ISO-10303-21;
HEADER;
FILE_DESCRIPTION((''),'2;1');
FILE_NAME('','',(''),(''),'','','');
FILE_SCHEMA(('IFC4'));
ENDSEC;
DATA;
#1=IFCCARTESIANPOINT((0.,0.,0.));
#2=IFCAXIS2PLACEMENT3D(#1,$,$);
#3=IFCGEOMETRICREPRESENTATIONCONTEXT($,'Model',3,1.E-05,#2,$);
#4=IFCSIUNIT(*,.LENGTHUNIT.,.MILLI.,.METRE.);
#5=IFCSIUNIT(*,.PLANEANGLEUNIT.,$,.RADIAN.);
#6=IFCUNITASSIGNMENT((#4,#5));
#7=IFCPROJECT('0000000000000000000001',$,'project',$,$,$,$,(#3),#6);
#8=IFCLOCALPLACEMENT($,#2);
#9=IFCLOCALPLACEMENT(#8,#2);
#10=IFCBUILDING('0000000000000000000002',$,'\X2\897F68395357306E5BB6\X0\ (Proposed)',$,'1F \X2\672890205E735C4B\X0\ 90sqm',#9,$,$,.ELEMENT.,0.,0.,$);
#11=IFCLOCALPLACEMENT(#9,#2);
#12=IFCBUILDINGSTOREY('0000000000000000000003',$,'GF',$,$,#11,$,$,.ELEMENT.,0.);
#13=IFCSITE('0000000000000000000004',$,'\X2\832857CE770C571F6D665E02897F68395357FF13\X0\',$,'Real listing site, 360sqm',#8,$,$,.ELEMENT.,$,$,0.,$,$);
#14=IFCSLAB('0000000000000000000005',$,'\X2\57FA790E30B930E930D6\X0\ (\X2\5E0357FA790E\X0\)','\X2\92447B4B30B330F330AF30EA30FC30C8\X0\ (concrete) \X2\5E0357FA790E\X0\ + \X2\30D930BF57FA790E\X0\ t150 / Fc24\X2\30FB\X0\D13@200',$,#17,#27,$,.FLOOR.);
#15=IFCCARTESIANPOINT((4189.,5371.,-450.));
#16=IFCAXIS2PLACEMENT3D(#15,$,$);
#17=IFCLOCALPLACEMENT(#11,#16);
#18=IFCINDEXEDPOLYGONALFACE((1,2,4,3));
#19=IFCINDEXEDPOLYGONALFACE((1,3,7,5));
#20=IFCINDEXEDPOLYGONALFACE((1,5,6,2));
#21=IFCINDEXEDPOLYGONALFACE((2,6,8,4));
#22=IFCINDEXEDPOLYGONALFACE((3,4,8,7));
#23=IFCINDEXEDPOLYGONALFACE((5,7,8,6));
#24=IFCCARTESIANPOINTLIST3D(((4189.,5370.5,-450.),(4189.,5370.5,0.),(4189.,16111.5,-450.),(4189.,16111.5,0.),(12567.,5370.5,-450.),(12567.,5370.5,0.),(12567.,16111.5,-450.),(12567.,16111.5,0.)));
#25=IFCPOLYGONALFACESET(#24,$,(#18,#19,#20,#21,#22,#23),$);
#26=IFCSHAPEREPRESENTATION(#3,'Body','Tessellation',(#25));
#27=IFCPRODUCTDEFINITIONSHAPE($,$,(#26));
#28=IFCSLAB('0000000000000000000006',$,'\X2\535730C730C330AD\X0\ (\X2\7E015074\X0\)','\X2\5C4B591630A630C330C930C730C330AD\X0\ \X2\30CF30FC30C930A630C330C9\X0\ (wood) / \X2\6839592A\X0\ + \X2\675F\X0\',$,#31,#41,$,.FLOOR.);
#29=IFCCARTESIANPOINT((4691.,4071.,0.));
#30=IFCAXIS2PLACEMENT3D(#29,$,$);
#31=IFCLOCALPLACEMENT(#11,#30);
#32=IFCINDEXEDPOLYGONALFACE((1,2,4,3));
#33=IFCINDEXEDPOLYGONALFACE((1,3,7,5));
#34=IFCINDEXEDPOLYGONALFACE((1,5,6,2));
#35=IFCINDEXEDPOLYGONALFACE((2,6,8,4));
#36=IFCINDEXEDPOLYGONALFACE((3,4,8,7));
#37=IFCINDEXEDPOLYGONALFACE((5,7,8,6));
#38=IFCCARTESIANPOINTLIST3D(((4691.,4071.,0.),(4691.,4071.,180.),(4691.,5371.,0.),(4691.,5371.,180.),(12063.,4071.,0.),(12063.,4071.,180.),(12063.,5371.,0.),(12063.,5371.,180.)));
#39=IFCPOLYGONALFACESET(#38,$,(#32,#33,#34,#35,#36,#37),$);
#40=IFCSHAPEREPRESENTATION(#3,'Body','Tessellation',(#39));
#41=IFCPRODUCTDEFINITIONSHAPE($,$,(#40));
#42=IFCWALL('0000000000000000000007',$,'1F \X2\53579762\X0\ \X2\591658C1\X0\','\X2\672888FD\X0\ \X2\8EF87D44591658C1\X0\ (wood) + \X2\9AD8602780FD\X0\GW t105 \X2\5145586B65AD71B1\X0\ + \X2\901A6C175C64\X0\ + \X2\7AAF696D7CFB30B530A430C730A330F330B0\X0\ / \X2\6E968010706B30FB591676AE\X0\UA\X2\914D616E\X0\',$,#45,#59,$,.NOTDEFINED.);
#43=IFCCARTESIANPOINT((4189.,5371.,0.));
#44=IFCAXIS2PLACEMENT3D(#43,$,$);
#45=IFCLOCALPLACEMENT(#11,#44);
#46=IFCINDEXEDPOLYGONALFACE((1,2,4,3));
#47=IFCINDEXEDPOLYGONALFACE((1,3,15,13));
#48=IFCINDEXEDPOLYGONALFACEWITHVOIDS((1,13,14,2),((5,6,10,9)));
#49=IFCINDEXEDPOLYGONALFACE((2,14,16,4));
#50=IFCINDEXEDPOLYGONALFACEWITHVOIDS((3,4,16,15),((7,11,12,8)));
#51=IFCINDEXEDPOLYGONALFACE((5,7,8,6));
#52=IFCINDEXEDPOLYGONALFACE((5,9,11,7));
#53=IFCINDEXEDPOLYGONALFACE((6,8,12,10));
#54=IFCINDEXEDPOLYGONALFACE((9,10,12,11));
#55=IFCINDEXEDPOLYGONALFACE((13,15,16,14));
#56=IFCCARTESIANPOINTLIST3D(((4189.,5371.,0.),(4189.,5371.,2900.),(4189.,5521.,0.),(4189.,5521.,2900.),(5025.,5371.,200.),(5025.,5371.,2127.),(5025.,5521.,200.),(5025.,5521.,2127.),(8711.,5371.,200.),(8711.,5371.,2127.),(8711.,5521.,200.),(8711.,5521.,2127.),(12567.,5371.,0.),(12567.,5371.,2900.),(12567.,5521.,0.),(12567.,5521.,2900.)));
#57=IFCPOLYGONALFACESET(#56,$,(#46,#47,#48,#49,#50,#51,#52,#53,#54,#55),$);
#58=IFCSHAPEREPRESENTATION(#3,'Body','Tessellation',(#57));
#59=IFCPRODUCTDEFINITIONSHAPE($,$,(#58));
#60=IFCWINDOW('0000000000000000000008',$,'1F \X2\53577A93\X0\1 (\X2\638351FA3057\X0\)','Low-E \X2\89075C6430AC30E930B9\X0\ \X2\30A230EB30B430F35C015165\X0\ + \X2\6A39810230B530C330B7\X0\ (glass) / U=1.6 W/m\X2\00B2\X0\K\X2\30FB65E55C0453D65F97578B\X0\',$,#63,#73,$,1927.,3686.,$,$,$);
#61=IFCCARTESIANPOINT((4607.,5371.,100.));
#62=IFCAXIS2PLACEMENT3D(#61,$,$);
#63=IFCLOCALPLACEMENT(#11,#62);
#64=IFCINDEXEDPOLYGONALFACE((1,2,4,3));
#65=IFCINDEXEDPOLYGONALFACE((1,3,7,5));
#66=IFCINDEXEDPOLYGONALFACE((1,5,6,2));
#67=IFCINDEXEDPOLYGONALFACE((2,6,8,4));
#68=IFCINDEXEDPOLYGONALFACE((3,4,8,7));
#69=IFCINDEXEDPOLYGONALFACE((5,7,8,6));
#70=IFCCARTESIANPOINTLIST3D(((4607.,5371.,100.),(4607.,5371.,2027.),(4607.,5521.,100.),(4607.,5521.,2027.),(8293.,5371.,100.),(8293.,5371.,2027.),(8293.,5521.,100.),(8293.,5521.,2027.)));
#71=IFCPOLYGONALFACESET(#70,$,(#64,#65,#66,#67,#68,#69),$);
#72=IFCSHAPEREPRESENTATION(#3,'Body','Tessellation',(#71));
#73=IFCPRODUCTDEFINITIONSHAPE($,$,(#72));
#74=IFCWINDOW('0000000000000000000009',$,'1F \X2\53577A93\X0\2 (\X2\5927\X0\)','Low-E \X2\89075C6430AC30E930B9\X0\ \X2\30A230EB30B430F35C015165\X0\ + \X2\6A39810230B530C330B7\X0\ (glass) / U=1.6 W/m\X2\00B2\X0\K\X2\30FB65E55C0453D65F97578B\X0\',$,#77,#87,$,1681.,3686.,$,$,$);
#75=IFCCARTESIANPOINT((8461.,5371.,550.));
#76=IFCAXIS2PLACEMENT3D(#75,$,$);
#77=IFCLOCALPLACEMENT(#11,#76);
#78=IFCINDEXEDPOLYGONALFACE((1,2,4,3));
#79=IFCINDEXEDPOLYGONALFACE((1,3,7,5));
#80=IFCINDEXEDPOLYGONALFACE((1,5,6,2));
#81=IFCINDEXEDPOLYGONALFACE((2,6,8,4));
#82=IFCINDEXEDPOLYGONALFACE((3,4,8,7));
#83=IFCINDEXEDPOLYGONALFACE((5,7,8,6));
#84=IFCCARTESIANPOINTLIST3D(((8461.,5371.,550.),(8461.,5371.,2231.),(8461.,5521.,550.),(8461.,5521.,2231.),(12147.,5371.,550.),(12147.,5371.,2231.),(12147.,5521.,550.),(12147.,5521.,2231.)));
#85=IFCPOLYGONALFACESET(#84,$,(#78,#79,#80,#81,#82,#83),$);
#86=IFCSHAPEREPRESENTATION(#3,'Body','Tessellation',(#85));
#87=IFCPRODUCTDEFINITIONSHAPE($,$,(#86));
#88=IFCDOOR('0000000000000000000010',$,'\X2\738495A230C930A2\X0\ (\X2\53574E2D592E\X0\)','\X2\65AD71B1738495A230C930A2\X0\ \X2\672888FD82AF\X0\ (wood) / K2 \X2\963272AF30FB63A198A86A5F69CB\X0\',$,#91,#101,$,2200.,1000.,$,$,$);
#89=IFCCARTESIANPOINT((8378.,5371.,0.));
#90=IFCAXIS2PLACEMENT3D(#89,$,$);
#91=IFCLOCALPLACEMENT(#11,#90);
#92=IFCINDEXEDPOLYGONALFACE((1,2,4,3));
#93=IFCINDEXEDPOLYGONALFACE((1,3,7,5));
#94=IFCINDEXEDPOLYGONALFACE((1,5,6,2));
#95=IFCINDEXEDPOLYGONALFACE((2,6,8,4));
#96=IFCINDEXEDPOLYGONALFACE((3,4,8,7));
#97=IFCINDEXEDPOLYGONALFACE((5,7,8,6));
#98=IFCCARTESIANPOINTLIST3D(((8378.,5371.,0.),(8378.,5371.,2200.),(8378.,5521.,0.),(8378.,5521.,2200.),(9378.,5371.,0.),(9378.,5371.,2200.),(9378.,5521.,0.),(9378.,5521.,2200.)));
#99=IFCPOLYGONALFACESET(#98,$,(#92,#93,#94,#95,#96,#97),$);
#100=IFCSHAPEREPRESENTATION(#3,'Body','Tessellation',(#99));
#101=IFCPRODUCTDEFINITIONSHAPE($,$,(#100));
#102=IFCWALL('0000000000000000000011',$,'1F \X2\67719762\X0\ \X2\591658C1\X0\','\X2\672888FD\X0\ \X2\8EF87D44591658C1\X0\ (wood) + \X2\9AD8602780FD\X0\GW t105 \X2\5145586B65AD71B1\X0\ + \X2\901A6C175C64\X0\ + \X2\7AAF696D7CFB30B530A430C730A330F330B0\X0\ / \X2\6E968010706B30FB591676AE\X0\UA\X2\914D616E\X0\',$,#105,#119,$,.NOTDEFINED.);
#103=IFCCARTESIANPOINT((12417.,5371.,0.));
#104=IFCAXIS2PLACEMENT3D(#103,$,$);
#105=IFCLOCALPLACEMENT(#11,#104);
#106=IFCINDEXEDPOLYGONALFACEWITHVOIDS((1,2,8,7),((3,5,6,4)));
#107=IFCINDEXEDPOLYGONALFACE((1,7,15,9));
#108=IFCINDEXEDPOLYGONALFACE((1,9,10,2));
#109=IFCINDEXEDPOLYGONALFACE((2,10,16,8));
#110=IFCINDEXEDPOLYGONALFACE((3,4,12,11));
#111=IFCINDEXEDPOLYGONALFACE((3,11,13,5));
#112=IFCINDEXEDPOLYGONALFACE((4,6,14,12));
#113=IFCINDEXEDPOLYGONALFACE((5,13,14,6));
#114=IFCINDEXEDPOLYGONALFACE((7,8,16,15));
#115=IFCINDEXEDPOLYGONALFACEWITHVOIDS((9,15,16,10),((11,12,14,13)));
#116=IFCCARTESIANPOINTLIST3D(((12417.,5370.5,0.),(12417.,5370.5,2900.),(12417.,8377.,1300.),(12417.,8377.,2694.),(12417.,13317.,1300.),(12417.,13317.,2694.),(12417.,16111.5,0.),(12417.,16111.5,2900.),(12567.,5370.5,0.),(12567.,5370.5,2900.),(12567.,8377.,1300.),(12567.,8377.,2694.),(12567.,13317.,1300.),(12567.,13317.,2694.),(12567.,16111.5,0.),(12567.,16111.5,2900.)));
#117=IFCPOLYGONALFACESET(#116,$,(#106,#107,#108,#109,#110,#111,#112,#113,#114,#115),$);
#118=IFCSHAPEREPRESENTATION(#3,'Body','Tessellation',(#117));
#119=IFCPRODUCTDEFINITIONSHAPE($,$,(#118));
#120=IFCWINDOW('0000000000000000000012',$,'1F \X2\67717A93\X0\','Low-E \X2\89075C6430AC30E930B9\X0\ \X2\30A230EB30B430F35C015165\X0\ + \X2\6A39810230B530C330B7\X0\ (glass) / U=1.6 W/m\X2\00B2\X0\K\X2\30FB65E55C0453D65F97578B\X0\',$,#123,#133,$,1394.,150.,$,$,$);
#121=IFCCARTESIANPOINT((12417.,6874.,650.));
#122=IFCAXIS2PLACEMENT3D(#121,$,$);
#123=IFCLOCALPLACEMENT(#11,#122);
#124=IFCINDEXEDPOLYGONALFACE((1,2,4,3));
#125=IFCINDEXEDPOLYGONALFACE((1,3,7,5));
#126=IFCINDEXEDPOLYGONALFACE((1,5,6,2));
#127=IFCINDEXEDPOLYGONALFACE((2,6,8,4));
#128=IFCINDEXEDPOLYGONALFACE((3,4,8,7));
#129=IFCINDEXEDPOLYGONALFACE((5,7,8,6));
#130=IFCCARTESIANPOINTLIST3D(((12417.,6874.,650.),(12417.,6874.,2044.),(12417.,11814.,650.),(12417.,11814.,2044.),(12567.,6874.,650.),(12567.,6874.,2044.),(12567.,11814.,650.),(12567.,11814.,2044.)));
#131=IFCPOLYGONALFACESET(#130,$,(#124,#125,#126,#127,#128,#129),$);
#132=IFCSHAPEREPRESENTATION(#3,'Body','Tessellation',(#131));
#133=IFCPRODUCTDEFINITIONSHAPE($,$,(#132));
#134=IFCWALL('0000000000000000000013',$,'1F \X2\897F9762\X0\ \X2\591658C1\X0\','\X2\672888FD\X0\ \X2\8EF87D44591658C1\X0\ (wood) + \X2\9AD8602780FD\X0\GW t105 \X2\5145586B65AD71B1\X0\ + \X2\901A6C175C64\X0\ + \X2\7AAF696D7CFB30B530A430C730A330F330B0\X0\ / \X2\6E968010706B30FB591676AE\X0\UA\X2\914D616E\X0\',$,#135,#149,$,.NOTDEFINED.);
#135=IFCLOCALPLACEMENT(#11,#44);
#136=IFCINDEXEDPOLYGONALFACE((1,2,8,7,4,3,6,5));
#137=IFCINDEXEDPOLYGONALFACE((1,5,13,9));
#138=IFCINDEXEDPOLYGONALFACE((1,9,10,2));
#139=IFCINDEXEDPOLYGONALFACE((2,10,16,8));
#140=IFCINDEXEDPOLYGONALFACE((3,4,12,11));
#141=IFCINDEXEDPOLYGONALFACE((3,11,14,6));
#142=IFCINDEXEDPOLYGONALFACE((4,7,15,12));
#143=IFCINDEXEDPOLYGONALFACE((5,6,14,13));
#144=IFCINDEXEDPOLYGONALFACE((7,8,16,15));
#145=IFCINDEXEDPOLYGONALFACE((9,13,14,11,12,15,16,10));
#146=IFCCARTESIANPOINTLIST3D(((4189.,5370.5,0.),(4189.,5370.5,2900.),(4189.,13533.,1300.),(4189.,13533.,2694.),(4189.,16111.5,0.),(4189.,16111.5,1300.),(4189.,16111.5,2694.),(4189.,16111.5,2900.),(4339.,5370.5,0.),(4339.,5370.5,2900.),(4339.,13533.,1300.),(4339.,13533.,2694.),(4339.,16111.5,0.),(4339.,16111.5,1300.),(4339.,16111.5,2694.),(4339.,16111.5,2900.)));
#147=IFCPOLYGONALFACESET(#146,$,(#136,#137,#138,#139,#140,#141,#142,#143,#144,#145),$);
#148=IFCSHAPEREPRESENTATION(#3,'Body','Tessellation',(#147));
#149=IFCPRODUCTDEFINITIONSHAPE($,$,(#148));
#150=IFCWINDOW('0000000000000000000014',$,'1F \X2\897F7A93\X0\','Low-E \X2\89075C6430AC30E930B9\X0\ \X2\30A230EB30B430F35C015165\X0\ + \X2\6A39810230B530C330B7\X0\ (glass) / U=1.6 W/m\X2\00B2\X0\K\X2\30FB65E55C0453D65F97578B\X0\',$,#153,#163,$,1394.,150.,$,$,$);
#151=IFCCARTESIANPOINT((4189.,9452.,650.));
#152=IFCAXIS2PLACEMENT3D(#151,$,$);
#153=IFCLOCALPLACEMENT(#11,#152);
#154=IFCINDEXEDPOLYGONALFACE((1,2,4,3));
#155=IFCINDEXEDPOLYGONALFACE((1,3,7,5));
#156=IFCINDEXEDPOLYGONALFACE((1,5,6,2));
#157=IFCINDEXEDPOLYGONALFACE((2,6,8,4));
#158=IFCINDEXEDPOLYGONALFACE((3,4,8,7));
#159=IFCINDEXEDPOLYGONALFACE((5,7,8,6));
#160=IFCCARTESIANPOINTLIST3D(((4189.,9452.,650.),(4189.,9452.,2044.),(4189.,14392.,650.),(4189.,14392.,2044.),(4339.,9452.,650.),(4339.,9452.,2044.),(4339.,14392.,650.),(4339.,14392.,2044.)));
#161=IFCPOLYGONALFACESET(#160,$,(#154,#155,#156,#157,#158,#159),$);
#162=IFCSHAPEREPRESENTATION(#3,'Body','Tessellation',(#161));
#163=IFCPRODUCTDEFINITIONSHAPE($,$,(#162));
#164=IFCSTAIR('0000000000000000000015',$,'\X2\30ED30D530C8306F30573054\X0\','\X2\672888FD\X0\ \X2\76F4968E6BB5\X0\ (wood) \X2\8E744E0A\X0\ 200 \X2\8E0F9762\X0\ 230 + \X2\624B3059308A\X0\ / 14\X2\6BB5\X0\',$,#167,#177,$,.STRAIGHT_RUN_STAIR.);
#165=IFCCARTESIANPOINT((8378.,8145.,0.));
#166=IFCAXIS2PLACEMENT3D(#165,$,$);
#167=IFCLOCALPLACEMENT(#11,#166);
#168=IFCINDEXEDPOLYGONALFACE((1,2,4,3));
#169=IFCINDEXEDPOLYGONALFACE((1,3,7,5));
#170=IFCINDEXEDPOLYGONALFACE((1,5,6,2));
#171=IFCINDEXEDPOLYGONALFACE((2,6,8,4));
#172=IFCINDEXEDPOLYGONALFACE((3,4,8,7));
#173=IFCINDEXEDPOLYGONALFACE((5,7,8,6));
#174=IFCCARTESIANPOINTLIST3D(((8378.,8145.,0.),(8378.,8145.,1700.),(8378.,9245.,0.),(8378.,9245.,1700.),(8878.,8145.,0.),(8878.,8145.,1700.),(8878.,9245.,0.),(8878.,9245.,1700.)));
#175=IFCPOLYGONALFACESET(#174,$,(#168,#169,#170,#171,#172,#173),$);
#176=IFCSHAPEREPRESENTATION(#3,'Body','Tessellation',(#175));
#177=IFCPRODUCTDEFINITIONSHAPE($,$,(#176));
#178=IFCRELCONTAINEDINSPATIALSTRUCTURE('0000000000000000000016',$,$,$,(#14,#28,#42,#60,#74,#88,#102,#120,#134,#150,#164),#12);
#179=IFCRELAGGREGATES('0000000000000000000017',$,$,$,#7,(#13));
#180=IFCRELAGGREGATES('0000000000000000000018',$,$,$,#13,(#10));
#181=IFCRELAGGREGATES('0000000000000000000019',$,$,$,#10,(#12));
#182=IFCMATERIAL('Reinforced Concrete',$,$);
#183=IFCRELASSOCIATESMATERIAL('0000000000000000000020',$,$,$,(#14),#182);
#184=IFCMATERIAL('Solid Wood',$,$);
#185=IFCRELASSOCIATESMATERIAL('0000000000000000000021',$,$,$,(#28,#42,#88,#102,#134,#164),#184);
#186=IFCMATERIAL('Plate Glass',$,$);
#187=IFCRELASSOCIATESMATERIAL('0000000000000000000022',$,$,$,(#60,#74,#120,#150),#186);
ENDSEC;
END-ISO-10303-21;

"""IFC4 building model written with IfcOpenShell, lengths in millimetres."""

from ifc_helpers import new_model, si_unit, frame, frame_2d, origin, place, context, project, spatial, rectangle, extrude, material, element, fill, save


model = new_model("IFC4")

# Units and contexts
model_context = context("Model", 3, precision=1e-05, world=origin())
ifc_project = project(units=[si_unit("LENGTHUNIT", "METRE", prefix="MILLI"), si_unit("PLANEANGLEUNIT", "RADIAN")], contexts=[model_context])

# Site, building, storey
site_placement = place(None, origin())
site = spatial("IfcSite", under=ifc_project, at=site_placement, Name="茨城県土浦市西根南３", ObjectType="Real listing site, 360sqm", CompositionType="ELEMENT", RefElevation=0.0)
building_placement = place(site_placement, origin())
building = spatial("IfcBuilding", under=site, at=building_placement, Name="西根南の家 (Proposed)", ObjectType="1F 木造平屋 90sqm", CompositionType="ELEMENT", ElevationOfRefHeight=0.0, ElevationOfTerrain=0.0)
storey_placement = place(building_placement, origin())
storey = spatial("IfcBuildingStorey", under=building, at=storey_placement, Name="GF", CompositionType="ELEMENT", Elevation=0.0)

# Slabs
ifc_material_1 = material(Name="Reinforced Concrete")
slab_1_placement = place(storey_placement, frame((4189.0, 5371.0, -450.0)))
element("IfcSlab", 1, at=slab_1_placement, inside=storey, material=ifc_material_1, Name="基礎スラブ (布基礎)", Description="鉄筋コンクリート (concrete) 布基礎 + ベタ基礎 t150 / Fc24・D13@200", PredefinedType="FLOOR", context=model_context, shape_type="SweptSolid", body=[
    extrude(rectangle(XDim=8378.0, YDim=10741.0, at=frame_2d((4189.0, 5370.0))), frame((4189.0, 5371.0, -450.0)), (0.0, 0.0, 1.0), 450.0),
])
ifc_material_2 = material(Name="Solid Wood")
slab_2_placement = place(storey_placement, frame((4691.0, 4071.0, 0.0)))
element("IfcSlab", 2, at=slab_2_placement, inside=storey, material=ifc_material_2, Name="南デッキ (縁側)", Description="屋外ウッドデッキ ハードウッド (wood) / 根太 + 束", PredefinedType="FLOOR", context=model_context, shape_type="SweptSolid", body=[
    extrude(rectangle(XDim=7372.0, YDim=1300.0, at=frame_2d((3686.0, 650.0))), frame((4691.0, 4071.0, 0.0)), (0.0, 0.0, 1.0), 180.0),
])

# Wall, openings, windows, door
wall_1_placement = place(storey_placement, frame((4189.0, 5371.0, 0.0)))
wall_1 = element("IfcWall", 3, at=wall_1_placement, inside=storey, material=ifc_material_2, Name="1F 南面 外壁", Description="木製 軸組外壁 (wood) + 高性能GW t105 充填断熱 + 通気層 + 窯業系サイディング / 準耐火・外皮UA配慮", PredefinedType="NOTDEFINED", context=model_context, shape_type="SweptSolid", body=[
    extrude(rectangle(XDim=8378.0, YDim=150.0, at=frame_2d((4189.0, 75.0))), frame((4189.0, 5371.0, 0.0)), (0.0, 0.0, 1.0), 2900.0),
])
opening_1_placement = place(storey_placement, frame((4607.0, 5371.0, 100.0)))
opening_1 = element("IfcOpeningElement", 4, at=opening_1_placement, cuts=wall_1, PredefinedType="NOTDEFINED", context=model_context, shape_type="SweptSolid", body=[
    extrude(rectangle(XDim=3686.0, YDim=150.0, at=frame_2d((1843.0, 75.0))), frame((4607.0, 5371.0, 100.0)), (0.0, 0.0, 1.0), 1927.0),
])
opening_2_placement = place(storey_placement, frame((8461.0, 5371.0, 550.0)))
opening_2 = element("IfcOpeningElement", 5, at=opening_2_placement, cuts=wall_1, PredefinedType="NOTDEFINED", context=model_context, shape_type="SweptSolid", body=[
    extrude(rectangle(XDim=3686.0, YDim=150.0, at=frame_2d((1843.0, 75.0))), frame((8461.0, 5371.0, 550.0)), (0.0, 0.0, 1.0), 1681.0),
])
opening_3_placement = place(storey_placement, frame((8378.0, 5371.0, 0.0)))
opening_3 = element("IfcOpeningElement", 6, at=opening_3_placement, cuts=wall_1, PredefinedType="NOTDEFINED", context=model_context, shape_type="SweptSolid", body=[
    extrude(rectangle(XDim=1000.0, YDim=150.0, at=frame_2d((500.0, 75.0))), frame((8378.0, 5371.0, 0.0)), (0.0, 0.0, 1.0), 2200.0),
])
ifc_material_3 = material(Name="Plate Glass")
window_1_placement = place(storey_placement, frame((4607.0, 5371.0, 100.0)))
window_1 = element("IfcWindow", 7, at=window_1_placement, inside=storey, material=ifc_material_3, Name="1F 南窓1 (掃出し)", Description="Low-E 複層ガラス アルゴン封入 + 樹脂サッシ (glass) / U=1.6 W/m²K・日射取得型", OverallHeight=1927.0, OverallWidth=3686.0, context=model_context, shape_type="SweptSolid", body=[
    extrude(rectangle(XDim=3686.0, YDim=150.0, at=frame_2d((1843.0, 75.0))), frame((4607.0, 5371.0, 100.0)), (0.0, 0.0, 1.0), 1927.0),
])
fill(opening_1, window_1)
window_2_placement = place(storey_placement, frame((8461.0, 5371.0, 550.0)))
window_2 = element("IfcWindow", 8, at=window_2_placement, inside=storey, material=ifc_material_3, Name="1F 南窓2 (大)", Description="Low-E 複層ガラス アルゴン封入 + 樹脂サッシ (glass) / U=1.6 W/m²K・日射取得型", OverallHeight=1681.0, OverallWidth=3686.0, context=model_context, shape_type="SweptSolid", body=[
    extrude(rectangle(XDim=3686.0, YDim=150.0, at=frame_2d((1843.0, 75.0))), frame((8461.0, 5371.0, 550.0)), (0.0, 0.0, 1.0), 1681.0),
])
fill(opening_2, window_2)
door_placement = place(storey_placement, frame((8378.0, 5371.0, 0.0)))
door = element("IfcDoor", 9, at=door_placement, inside=storey, material=ifc_material_2, Name="玄関ドア (南中央)", Description="断熱玄関ドア 木製芯 (wood) / K2 防犯・採風機構", OverallHeight=2200.0, OverallWidth=1000.0, context=model_context, shape_type="SweptSolid", body=[
    extrude(rectangle(XDim=1000.0, YDim=150.0, at=frame_2d((500.0, 75.0))), frame((8378.0, 5371.0, 0.0)), (0.0, 0.0, 1.0), 2200.0),
])
fill(opening_3, door)

# Walls, openings, windows
wall_2_placement = place(storey_placement, frame((12417.0, 5371.0, 0.0)))
wall_2 = element("IfcWall", 10, at=wall_2_placement, inside=storey, material=ifc_material_2, Name="1F 東面 外壁", Description="木製 軸組外壁 (wood) + 高性能GW t105 充填断熱 + 通気層 + 窯業系サイディング / 準耐火・外皮UA配慮", PredefinedType="NOTDEFINED", context=model_context, shape_type="SweptSolid", body=[
    extrude(rectangle(XDim=150.0, YDim=10741.0, at=frame_2d((75.0, 5370.0))), frame((12417.0, 5371.0, 0.0)), (0.0, 0.0, 1.0), 2900.0),
])
opening_4_placement = place(storey_placement, frame((12417.0, 6874.0, 650.0)))
opening_4 = element("IfcOpeningElement", 11, at=opening_4_placement, cuts=wall_2, PredefinedType="NOTDEFINED", context=model_context, shape_type="SweptSolid", body=[
    extrude(rectangle(XDim=150.0, YDim=4940.0, at=frame_2d((75.0, 2470.0))), frame((12417.0, 6874.0, 650.0)), (0.0, 0.0, 1.0), 1394.0),
])
window_3_placement = place(storey_placement, frame((12417.0, 6874.0, 650.0)))
window_3 = element("IfcWindow", 12, at=window_3_placement, inside=storey, material=ifc_material_3, Name="1F 東窓", Description="Low-E 複層ガラス アルゴン封入 + 樹脂サッシ (glass) / U=1.6 W/m²K・日射取得型", OverallHeight=1394.0, OverallWidth=150.0, context=model_context, shape_type="SweptSolid", body=[
    extrude(rectangle(XDim=150.0, YDim=4940.0, at=frame_2d((75.0, 2470.0))), frame((12417.0, 6874.0, 650.0)), (0.0, 0.0, 1.0), 1394.0),
])
fill(opening_4, window_3)
wall_3_placement = place(storey_placement, frame((4189.0, 5371.0, 0.0)))
wall_3 = element("IfcWall", 13, at=wall_3_placement, inside=storey, material=ifc_material_2, Name="1F 西面 外壁", Description="木製 軸組外壁 (wood) + 高性能GW t105 充填断熱 + 通気層 + 窯業系サイディング / 準耐火・外皮UA配慮", PredefinedType="NOTDEFINED", context=model_context, shape_type="SweptSolid", body=[
    extrude(rectangle(XDim=150.0, YDim=10741.0, at=frame_2d((75.0, 5370.0))), frame((4189.0, 5371.0, 0.0)), (0.0, 0.0, 1.0), 2900.0),
])
opening_5_placement = place(storey_placement, frame((4189.0, 9452.0, 650.0)))
opening_5 = element("IfcOpeningElement", 14, at=opening_5_placement, cuts=wall_3, PredefinedType="NOTDEFINED", context=model_context, shape_type="SweptSolid", body=[
    extrude(rectangle(XDim=150.0, YDim=4940.0, at=frame_2d((75.0, 2470.0))), frame((4189.0, 9452.0, 650.0)), (0.0, 0.0, 1.0), 1394.0),
])
window_4_placement = place(storey_placement, frame((4189.0, 9452.0, 650.0)))
window_4 = element("IfcWindow", 15, at=window_4_placement, inside=storey, material=ifc_material_3, Name="1F 西窓", Description="Low-E 複層ガラス アルゴン封入 + 樹脂サッシ (glass) / U=1.6 W/m²K・日射取得型", OverallHeight=1394.0, OverallWidth=150.0, context=model_context, shape_type="SweptSolid", body=[
    extrude(rectangle(XDim=150.0, YDim=4940.0, at=frame_2d((75.0, 2470.0))), frame((4189.0, 9452.0, 650.0)), (0.0, 0.0, 1.0), 1394.0),
])
fill(opening_5, window_4)

# Stair
stair_placement = place(storey_placement, frame((8378.0, 8145.0, 0.0)))
element("IfcStair", 16, at=stair_placement, inside=storey, material=ifc_material_2, Name="ロフトはしご", Description="木製 直階段 (wood) 蹴上 200 踏面 230 + 手すり / 14段", PredefinedType="STRAIGHT_RUN_STAIR", context=model_context, shape_type="SweptSolid", body=[
    extrude(rectangle(XDim=500.0, YDim=1100.0, at=frame_2d((250.0, 550.0))), frame((8378.0, 8145.0, 0.0)), (0.0, 0.0, 1.0), 1700.0),
])

save(model, "model.ifc")
